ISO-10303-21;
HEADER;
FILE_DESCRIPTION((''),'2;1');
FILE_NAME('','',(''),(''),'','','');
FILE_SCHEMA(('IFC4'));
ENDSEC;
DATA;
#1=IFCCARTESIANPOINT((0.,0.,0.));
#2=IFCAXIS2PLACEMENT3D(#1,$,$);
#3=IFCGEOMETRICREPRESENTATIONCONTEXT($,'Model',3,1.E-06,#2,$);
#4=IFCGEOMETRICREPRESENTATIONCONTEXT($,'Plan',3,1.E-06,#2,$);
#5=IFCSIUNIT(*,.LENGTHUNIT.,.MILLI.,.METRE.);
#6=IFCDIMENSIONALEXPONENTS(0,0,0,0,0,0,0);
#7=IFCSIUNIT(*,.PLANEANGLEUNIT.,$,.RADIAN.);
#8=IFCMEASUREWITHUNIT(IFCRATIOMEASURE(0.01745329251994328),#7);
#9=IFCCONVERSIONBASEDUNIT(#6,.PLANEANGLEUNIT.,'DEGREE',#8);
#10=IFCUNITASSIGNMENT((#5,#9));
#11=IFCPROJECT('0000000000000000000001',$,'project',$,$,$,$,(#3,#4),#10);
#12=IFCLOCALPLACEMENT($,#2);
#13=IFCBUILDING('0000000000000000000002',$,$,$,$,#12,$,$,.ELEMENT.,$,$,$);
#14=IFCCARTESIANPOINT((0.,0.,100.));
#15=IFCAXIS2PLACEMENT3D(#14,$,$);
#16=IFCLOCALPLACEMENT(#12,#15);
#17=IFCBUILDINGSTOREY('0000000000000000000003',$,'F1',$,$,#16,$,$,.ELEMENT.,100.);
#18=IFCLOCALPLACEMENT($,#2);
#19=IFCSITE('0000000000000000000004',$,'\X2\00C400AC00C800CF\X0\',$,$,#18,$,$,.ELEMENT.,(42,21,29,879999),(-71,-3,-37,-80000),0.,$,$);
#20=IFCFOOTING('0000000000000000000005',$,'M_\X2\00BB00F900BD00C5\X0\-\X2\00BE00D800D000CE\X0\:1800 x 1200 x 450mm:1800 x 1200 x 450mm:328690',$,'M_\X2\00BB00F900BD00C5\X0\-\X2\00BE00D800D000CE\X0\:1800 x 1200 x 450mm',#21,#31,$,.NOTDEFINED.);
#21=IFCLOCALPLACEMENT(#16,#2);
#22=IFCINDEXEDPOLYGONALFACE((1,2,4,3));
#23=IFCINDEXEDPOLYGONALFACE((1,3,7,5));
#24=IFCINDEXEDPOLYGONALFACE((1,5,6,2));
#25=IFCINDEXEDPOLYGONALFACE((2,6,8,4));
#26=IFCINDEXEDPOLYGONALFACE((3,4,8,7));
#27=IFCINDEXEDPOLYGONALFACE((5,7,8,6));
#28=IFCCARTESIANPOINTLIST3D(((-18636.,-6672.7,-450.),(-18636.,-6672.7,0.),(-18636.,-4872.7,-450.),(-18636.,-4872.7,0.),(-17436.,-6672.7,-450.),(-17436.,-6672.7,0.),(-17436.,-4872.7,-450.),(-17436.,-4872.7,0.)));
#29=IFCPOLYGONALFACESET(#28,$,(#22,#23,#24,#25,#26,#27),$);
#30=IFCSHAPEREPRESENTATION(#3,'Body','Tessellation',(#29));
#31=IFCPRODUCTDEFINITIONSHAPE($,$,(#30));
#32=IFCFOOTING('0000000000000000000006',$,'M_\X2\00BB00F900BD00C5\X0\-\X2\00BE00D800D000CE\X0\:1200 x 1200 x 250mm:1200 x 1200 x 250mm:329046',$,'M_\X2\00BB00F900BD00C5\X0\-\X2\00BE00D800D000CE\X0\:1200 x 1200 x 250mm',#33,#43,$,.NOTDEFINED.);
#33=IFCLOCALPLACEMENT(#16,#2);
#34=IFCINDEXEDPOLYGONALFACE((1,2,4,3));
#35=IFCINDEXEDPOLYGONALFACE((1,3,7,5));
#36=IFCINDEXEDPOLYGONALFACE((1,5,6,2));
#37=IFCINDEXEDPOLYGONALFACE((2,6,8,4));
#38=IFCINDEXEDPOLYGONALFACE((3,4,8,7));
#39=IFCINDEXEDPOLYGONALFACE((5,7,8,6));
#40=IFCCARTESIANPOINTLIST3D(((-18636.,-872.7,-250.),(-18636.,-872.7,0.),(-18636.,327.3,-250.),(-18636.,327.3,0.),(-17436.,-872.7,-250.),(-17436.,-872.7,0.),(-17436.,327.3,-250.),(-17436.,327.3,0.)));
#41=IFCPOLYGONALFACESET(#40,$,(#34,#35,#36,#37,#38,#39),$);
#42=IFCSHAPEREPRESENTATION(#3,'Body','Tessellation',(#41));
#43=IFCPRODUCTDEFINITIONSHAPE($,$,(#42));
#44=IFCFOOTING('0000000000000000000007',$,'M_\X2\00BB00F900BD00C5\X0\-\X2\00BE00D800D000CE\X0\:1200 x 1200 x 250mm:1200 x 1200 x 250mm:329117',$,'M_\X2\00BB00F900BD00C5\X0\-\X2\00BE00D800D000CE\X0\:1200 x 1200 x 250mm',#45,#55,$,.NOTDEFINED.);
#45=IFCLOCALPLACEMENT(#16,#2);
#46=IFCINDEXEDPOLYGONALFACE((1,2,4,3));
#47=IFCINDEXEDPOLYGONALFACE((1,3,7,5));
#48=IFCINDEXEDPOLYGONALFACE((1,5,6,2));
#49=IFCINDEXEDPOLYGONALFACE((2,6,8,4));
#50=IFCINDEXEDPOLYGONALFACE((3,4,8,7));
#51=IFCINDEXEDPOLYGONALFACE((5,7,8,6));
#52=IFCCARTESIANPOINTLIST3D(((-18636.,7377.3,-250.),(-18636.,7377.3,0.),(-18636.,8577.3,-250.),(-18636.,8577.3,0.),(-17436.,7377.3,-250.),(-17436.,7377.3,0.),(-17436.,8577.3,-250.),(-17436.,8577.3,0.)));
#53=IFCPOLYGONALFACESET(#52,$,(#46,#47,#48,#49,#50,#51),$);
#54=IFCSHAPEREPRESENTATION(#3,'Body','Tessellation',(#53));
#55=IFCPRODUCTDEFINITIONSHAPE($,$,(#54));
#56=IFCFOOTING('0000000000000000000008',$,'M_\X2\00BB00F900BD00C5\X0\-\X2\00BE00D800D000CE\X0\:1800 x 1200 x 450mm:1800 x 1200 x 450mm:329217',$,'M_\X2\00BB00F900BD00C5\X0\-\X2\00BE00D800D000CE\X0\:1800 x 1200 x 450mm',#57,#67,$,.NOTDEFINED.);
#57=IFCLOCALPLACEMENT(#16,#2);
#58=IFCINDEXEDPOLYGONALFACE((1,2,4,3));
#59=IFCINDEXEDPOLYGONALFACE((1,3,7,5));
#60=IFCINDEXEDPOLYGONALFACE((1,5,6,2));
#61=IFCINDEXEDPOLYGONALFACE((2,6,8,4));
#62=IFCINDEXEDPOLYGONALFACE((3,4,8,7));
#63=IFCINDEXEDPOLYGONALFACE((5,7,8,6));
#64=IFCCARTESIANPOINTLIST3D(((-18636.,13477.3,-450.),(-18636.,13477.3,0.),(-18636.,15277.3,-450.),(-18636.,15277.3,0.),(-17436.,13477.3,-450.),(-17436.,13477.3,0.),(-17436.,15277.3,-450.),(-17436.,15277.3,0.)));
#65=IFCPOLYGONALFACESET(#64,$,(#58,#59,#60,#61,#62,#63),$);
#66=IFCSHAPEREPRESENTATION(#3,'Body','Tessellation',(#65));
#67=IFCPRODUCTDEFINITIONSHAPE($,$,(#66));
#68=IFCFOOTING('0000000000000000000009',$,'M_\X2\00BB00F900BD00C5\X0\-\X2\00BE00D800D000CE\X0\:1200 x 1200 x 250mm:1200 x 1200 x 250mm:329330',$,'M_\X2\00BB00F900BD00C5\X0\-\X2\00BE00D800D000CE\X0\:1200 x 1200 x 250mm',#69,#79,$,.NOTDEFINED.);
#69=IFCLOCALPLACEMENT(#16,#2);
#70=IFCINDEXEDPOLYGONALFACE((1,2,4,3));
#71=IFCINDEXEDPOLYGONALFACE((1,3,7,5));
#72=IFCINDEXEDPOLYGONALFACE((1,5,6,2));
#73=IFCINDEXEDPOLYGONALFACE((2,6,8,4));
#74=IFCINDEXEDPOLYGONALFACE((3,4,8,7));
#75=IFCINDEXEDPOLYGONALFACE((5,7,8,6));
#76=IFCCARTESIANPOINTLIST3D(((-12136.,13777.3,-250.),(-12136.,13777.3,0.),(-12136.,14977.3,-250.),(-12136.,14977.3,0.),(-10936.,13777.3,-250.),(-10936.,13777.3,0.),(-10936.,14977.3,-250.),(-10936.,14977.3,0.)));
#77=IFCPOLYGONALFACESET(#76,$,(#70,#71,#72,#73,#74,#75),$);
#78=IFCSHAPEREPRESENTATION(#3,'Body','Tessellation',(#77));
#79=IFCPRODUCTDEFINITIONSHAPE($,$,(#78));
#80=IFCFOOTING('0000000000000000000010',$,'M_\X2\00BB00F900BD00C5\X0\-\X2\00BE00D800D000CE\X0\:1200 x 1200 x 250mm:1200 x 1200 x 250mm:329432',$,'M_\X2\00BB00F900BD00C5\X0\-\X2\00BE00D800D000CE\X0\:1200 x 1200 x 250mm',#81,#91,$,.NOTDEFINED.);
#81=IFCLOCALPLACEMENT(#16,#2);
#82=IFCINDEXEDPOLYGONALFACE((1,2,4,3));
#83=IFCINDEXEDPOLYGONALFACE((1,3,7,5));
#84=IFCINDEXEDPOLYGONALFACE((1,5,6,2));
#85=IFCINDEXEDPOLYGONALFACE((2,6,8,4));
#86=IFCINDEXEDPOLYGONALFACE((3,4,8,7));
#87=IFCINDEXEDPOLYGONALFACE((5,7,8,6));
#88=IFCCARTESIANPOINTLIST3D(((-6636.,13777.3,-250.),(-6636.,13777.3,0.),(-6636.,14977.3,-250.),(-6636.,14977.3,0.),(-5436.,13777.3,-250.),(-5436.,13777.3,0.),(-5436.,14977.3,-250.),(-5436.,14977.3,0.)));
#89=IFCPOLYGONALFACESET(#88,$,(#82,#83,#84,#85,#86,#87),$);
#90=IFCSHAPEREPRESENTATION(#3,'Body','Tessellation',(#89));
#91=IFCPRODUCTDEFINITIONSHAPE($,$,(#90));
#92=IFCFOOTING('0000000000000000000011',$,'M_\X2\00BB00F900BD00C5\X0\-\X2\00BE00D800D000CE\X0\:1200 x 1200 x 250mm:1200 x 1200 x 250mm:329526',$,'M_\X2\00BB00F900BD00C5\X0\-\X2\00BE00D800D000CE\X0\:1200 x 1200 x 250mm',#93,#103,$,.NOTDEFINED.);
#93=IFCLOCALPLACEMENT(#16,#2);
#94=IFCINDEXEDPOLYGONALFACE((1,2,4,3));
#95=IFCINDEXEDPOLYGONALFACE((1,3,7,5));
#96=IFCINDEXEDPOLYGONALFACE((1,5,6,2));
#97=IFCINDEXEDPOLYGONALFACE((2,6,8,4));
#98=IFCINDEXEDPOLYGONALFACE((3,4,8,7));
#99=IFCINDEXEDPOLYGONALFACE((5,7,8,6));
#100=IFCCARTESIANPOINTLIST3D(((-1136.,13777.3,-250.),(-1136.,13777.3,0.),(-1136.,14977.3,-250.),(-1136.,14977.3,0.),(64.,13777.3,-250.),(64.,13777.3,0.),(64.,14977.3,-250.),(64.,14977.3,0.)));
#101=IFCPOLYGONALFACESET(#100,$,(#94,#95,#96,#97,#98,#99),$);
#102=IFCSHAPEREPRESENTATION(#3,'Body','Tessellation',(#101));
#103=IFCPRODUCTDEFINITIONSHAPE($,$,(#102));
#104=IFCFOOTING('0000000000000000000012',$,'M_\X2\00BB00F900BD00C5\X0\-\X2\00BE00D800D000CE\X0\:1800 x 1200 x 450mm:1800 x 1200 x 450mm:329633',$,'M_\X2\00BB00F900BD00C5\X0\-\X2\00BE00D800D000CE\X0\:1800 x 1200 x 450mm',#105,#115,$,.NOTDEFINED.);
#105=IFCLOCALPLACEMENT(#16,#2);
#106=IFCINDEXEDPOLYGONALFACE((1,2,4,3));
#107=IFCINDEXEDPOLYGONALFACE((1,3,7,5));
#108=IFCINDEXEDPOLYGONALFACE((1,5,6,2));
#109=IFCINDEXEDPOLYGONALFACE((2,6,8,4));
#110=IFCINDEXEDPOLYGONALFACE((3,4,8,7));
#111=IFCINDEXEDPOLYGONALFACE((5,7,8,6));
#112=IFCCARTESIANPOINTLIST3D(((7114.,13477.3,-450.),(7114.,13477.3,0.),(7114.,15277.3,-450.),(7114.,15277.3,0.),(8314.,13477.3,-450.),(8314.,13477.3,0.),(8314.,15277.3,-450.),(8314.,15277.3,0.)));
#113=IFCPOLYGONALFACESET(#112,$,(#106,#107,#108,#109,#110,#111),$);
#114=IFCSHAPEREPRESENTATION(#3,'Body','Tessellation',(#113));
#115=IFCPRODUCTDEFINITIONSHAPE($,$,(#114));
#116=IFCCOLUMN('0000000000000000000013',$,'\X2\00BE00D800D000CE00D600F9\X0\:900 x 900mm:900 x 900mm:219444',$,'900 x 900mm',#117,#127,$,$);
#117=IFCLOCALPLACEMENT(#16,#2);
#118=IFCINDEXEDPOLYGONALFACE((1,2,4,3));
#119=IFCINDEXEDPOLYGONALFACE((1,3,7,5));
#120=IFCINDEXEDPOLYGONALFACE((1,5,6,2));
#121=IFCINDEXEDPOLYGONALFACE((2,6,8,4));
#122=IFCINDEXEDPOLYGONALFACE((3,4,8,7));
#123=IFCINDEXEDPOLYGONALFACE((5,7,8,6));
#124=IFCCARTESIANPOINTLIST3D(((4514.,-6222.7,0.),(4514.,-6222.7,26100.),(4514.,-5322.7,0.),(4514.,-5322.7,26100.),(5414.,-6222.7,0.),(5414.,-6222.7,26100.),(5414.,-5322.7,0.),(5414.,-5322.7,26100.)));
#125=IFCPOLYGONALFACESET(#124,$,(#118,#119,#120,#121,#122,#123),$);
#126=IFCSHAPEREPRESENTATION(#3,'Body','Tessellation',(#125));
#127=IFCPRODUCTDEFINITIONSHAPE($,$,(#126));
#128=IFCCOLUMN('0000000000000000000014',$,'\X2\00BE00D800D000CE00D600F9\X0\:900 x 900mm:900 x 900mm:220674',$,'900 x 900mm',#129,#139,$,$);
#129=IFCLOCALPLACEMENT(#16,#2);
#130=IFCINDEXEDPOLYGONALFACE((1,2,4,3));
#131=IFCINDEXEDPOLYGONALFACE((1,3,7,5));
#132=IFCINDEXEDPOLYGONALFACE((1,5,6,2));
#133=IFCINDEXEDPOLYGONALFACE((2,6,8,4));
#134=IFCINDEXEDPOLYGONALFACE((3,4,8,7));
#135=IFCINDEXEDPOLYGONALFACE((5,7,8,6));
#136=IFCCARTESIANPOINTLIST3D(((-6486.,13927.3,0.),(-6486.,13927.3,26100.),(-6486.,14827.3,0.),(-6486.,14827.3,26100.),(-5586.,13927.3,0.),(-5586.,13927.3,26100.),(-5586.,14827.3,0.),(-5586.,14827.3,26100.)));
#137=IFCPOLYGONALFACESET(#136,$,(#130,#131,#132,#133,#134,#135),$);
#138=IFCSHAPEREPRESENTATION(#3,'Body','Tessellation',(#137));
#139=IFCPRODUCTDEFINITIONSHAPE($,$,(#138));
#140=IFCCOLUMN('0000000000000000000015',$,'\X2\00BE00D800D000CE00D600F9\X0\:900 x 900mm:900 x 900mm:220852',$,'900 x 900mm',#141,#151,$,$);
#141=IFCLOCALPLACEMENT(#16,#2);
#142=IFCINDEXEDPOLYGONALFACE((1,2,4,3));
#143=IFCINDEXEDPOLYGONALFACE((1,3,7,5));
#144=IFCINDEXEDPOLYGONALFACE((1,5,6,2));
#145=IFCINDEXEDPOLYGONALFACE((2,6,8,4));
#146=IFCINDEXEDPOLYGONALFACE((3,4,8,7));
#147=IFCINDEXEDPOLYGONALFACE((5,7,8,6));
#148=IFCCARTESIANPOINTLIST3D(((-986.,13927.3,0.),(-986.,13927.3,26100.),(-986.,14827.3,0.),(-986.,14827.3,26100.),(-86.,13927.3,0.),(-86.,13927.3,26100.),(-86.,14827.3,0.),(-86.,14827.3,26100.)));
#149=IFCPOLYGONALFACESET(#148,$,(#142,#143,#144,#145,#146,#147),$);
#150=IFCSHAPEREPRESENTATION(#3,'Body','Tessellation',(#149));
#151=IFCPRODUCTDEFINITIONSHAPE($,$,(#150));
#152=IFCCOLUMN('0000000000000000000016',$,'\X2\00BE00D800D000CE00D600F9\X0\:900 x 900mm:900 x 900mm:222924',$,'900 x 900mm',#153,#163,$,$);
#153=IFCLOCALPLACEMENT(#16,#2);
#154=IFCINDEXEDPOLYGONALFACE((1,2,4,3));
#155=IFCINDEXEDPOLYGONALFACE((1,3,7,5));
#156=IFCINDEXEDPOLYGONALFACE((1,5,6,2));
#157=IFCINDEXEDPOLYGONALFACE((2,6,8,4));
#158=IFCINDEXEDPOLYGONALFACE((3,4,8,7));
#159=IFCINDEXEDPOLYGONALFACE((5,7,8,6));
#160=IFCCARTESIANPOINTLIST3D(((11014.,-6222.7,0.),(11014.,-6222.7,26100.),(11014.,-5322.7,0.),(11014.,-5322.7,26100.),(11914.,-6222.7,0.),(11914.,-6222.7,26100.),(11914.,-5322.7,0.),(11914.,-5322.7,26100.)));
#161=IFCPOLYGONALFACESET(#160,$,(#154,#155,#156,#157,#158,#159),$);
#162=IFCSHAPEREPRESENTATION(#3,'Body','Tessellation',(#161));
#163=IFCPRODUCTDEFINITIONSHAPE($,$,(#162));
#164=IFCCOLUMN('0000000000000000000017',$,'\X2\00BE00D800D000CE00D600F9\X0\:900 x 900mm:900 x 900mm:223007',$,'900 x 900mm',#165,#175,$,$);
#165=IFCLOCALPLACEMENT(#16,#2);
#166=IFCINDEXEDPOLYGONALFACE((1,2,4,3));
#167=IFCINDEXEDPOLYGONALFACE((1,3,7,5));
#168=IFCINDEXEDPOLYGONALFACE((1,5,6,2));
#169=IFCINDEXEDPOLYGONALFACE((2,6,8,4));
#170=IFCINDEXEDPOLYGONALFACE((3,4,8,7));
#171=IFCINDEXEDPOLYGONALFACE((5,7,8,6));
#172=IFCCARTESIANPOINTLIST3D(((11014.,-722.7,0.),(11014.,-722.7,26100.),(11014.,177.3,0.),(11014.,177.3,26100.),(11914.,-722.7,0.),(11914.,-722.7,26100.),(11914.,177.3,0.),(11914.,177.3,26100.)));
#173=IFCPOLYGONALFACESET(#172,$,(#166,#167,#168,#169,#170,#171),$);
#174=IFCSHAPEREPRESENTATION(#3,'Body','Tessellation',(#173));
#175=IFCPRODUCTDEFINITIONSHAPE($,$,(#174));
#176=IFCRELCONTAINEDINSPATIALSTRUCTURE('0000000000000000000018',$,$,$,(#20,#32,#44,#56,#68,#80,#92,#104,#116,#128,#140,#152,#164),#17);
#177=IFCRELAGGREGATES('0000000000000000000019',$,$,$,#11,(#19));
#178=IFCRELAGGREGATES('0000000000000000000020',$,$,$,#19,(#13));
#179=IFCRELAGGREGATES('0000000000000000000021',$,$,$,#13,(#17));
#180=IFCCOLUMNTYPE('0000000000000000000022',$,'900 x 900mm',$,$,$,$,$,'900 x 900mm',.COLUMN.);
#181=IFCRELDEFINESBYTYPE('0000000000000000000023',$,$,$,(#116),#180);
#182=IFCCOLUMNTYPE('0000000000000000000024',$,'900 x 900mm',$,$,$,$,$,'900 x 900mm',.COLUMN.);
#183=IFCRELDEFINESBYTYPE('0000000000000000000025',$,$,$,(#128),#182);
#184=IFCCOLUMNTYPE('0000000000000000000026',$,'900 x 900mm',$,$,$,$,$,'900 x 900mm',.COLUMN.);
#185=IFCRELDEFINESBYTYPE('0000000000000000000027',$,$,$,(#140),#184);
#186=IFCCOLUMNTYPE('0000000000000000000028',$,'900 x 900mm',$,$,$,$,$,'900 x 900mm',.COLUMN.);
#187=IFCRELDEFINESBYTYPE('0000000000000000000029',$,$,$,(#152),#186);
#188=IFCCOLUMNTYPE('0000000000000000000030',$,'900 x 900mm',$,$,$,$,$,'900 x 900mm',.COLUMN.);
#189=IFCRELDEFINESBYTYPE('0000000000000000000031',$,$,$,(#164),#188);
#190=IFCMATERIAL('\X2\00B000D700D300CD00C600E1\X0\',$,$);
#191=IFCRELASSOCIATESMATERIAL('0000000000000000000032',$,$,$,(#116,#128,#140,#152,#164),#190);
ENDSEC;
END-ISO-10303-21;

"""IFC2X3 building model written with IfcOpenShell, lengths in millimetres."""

from ifc_helpers import new_model, entity, si_unit, converted_unit, frame, frame_2d, origin, origin_2d_with_axis, place, context, project, spatial, rectangle, extrude, source, transform, mapped, material, type_object, type_shapes, element, save


model = new_model("IFC2X3")

# Units and contexts
model_context = context("Model", 3, precision=1e-06, world=origin())
plan_context = context("Plan", 3, precision=1e-06, world=origin())
ifc_project = project(units=[si_unit("LENGTHUNIT", "METRE", prefix="MILLI"), converted_unit("PLANEANGLEUNIT", "DEGREE", entity("IfcRatioMeasure", 0.01745329251994328), si_unit("PLANEANGLEUNIT", "RADIAN"), dimensions=[0, 0, 0, 0, 0, 0, 0])], contexts=[model_context, plan_context])

# Site, building, storey
site_placement = place(None, origin())
site = spatial("IfcSite", under=ifc_project, at=site_placement, Name="Ä¬ÈÏ", CompositionType="ELEMENT", RefLatitude=(42, 21, 29, 879999), RefLongitude=(-71, -3, -37, -80000), RefElevation=0.0)
building_placement = place(None, origin())
building = spatial("IfcBuilding", under=site, at=building_placement, CompositionType="ELEMENT")
storey_placement = place(building_placement, frame((0.0, 0.0, 100.0)))
storey = spatial("IfcBuildingStorey", under=building, at=storey_placement, Name="F1", CompositionType="ELEMENT", Elevation=100.0)

# Footings
footing_1_placement = place(storey_placement, origin())
element("IfcFooting", 1, at=footing_1_placement, inside=storey, Name="M_»ù½Å-¾ØÐÎ:1800 x 1200 x 450mm:1800 x 1200 x 450mm:328690", ObjectType="M_»ù½Å-¾ØÐÎ:1800 x 1200 x 450mm", PredefinedType="NOTDEFINED", context=model_context, shape_type="SweptSolid", body=[
    extrude(rectangle(XDim=1200.0, YDim=1800.0, at=origin_2d_with_axis()), frame((-18036.0, -5772.7, -450.0), z_axis=(0.0, 0.0, 1.0), x_axis=(-1.0, 0.0, 0.0)), (0.0, 0.0, 1.0), 450.0),
])
footing_2_placement = place(storey_placement, origin())
element("IfcFooting", 2, at=footing_2_placement, inside=storey, Name="M_»ù½Å-¾ØÐÎ:1200 x 1200 x 250mm:1200 x 1200 x 250mm:329046", ObjectType="M_»ù½Å-¾ØÐÎ:1200 x 1200 x 250mm", PredefinedType="NOTDEFINED", context=model_context, shape_type="SweptSolid", body=[
    extrude(rectangle(XDim=1200.0, YDim=1200.0, at=origin_2d_with_axis()), frame((-18036.0, -272.7, -250.0), z_axis=(0.0, 0.0, 1.0), x_axis=(-1.0, 0.0, 0.0)), (0.0, 0.0, 1.0), 250.0),
])
footing_3_placement = place(storey_placement, origin())
element("IfcFooting", 3, at=footing_3_placement, inside=storey, Name="M_»ù½Å-¾ØÐÎ:1200 x 1200 x 250mm:1200 x 1200 x 250mm:329117", ObjectType="M_»ù½Å-¾ØÐÎ:1200 x 1200 x 250mm", PredefinedType="NOTDEFINED", context=model_context, shape_type="SweptSolid", body=[
    extrude(rectangle(XDim=1200.0, YDim=1200.0, at=origin_2d_with_axis()), frame((-18036.0, 7977.3, -250.0), z_axis=(0.0, 0.0, 1.0), x_axis=(-1.0, 0.0, 0.0)), (0.0, 0.0, 1.0), 250.0),
])
footing_4_placement = place(storey_placement, origin())
element("IfcFooting", 4, at=footing_4_placement, inside=storey, Name="M_»ù½Å-¾ØÐÎ:1800 x 1200 x 450mm:1800 x 1200 x 450mm:329217", ObjectType="M_»ù½Å-¾ØÐÎ:1800 x 1200 x 450mm", PredefinedType="NOTDEFINED", context=model_context, shape_type="SweptSolid", body=[
    extrude(rectangle(XDim=1200.0, YDim=1800.0, at=origin_2d_with_axis()), frame((-18036.0, 14377.3, -450.0), z_axis=(0.0, 0.0, 1.0), x_axis=(-1.0, 0.0, 0.0)), (0.0, 0.0, 1.0), 450.0),
])
footing_5_placement = place(storey_placement, origin())
element("IfcFooting", 5, at=footing_5_placement, inside=storey, Name="M_»ù½Å-¾ØÐÎ:1200 x 1200 x 250mm:1200 x 1200 x 250mm:329330", ObjectType="M_»ù½Å-¾ØÐÎ:1200 x 1200 x 250mm", PredefinedType="NOTDEFINED", context=model_context, shape_type="SweptSolid", body=[
    extrude(rectangle(XDim=1200.0, YDim=1200.0, at=origin_2d_with_axis()), frame((-11536.0, 14377.3, -250.0), z_axis=(0.0, 0.0, 1.0), x_axis=(-1.0, 0.0, 0.0)), (0.0, 0.0, 1.0), 250.0),
])
footing_6_placement = place(storey_placement, origin())
element("IfcFooting", 6, at=footing_6_placement, inside=storey, Name="M_»ù½Å-¾ØÐÎ:1200 x 1200 x 250mm:1200 x 1200 x 250mm:329432", ObjectType="M_»ù½Å-¾ØÐÎ:1200 x 1200 x 250mm", PredefinedType="NOTDEFINED", context=model_context, shape_type="SweptSolid", body=[
    extrude(rectangle(XDim=1200.0, YDim=1200.0, at=origin_2d_with_axis()), frame((-6036.0, 14377.3, -250.0), z_axis=(0.0, 0.0, 1.0), x_axis=(-1.0, 0.0, 0.0)), (0.0, 0.0, 1.0), 250.0),
])
footing_7_placement = place(storey_placement, origin())
element("IfcFooting", 7, at=footing_7_placement, inside=storey, Name="M_»ù½Å-¾ØÐÎ:1200 x 1200 x 250mm:1200 x 1200 x 250mm:329526", ObjectType="M_»ù½Å-¾ØÐÎ:1200 x 1200 x 250mm", PredefinedType="NOTDEFINED", context=model_context, shape_type="SweptSolid", body=[
    extrude(rectangle(XDim=1200.0, YDim=1200.0, at=origin_2d_with_axis()), frame((-536.0, 14377.3, -250.0), z_axis=(0.0, 0.0, 1.0), x_axis=(-1.0, 0.0, 0.0)), (0.0, 0.0, 1.0), 250.0),
])
footing_8_placement = place(storey_placement, origin())
element("IfcFooting", 8, at=footing_8_placement, inside=storey, Name="M_»ù½Å-¾ØÐÎ:1800 x 1200 x 450mm:1800 x 1200 x 450mm:329633", ObjectType="M_»ù½Å-¾ØÐÎ:1800 x 1200 x 450mm", PredefinedType="NOTDEFINED", context=model_context, shape_type="SweptSolid", body=[
    extrude(rectangle(XDim=1200.0, YDim=1800.0, at=origin_2d_with_axis()), frame((7714.0, 14377.3, -450.0), z_axis=(0.0, 0.0, 1.0), x_axis=(-1.0, 0.0, 0.0)), (0.0, 0.0, 1.0), 450.0),
])

# Columns
ifc_material_1 = material(Name="°×ÓÍÆá")
column_type_1 = type_object("IfcColumnType", Name="900 x 900mm", ElementType="900 x 900mm", PredefinedType="COLUMN")
shared_shape_1 = source(origin(), model_context, "Body", "SweptSolid", [
    extrude(rectangle(XDim=900.0, YDim=900.0, at=frame_2d((0.0, 0.0), x_axis=(0.0, -1.0))), origin(), (0.0, 0.0, 1.0), 26100.0),
])
type_shapes(column_type_1, [shared_shape_1])
column_1_placement = place(storey_placement, frame((4964.0, -5772.7, 0.0)))
element("IfcColumn", 9, at=column_1_placement, inside=storey, type_object=column_type_1, material=ifc_material_1, Name="¾ØÐÎÖù:900 x 900mm:900 x 900mm:219444", ObjectType="900 x 900mm", context=model_context, shape_type="MappedRepresentation", body=[
    mapped(shared_shape_1, transform((0.0, 0.0, 0.0), scale=1.0)),
])
column_type_2 = type_object("IfcColumnType", Name="900 x 900mm", ElementType="900 x 900mm", PredefinedType="COLUMN")
shared_shape_2 = source(origin(), model_context, "Body", "SweptSolid", [
    extrude(rectangle(XDim=900.0, YDim=900.0, at=frame_2d((-6036.0, 14377.3), x_axis=(0.0, -1.0))), origin(), (0.0, 0.0, 1.0), 26100.0),
])
type_shapes(column_type_2, [shared_shape_2])
column_2_placement = place(storey_placement, origin())
element("IfcColumn", 10, at=column_2_placement, inside=storey, type_object=column_type_2, material=ifc_material_1, Name="¾ØÐÎÖù:900 x 900mm:900 x 900mm:220674", ObjectType="900 x 900mm", context=model_context, shape_type="MappedRepresentation", body=[
    mapped(shared_shape_2, transform((0.0, 0.0, 0.0), scale=1.0)),
])
column_type_3 = type_object("IfcColumnType", Name="900 x 900mm", ElementType="900 x 900mm", PredefinedType="COLUMN")
shared_shape_3 = source(origin(), model_context, "Body", "SweptSolid", [
    extrude(rectangle(XDim=900.0, YDim=900.0, at=frame_2d((-536.0, 14377.3), x_axis=(0.0, -1.0))), origin(), (0.0, 0.0, 1.0), 26100.0),
])
type_shapes(column_type_3, [shared_shape_3])
column_3_placement = place(storey_placement, origin())
element("IfcColumn", 11, at=column_3_placement, inside=storey, type_object=column_type_3, material=ifc_material_1, Name="¾ØÐÎÖù:900 x 900mm:900 x 900mm:220852", ObjectType="900 x 900mm", context=model_context, shape_type="MappedRepresentation", body=[
    mapped(shared_shape_3, transform((0.0, 0.0, 0.0), scale=1.0)),
])
column_type_4 = type_object("IfcColumnType", Name="900 x 900mm", ElementType="900 x 900mm", PredefinedType="COLUMN")
shared_shape_4 = source(origin(), model_context, "Body", "SweptSolid", [
    extrude(rectangle(XDim=900.0, YDim=900.0, at=frame_2d((11464.0, -5772.7), x_axis=(0.0, -1.0))), origin(), (0.0, 0.0, 1.0), 26100.0),
])
type_shapes(column_type_4, [shared_shape_4])
column_4_placement = place(storey_placement, origin())
element("IfcColumn", 12, at=column_4_placement, inside=storey, type_object=column_type_4, material=ifc_material_1, Name="¾ØÐÎÖù:900 x 900mm:900 x 900mm:222924", ObjectType="900 x 900mm", context=model_context, shape_type="MappedRepresentation", body=[
    mapped(shared_shape_4, transform((0.0, 0.0, 0.0), scale=1.0)),
])
column_type_5 = type_object("IfcColumnType", Name="900 x 900mm", ElementType="900 x 900mm", PredefinedType="COLUMN")
shared_shape_5 = source(origin(), model_context, "Body", "SweptSolid", [
    extrude(rectangle(XDim=900.0, YDim=900.0, at=frame_2d((11464.0, -272.7), x_axis=(0.0, -1.0))), origin(), (0.0, 0.0, 1.0), 26100.0),
])
type_shapes(column_type_5, [shared_shape_5])
column_5_placement = place(storey_placement, origin())
element("IfcColumn", 13, at=column_5_placement, inside=storey, type_object=column_type_5, material=ifc_material_1, Name="¾ØÐÎÖù:900 x 900mm:900 x 900mm:223007", ObjectType="900 x 900mm", context=model_context, shape_type="MappedRepresentation", body=[
    mapped(shared_shape_5, transform((0.0, 0.0, 0.0), scale=1.0)),
])

save(model, "model.ifc")
